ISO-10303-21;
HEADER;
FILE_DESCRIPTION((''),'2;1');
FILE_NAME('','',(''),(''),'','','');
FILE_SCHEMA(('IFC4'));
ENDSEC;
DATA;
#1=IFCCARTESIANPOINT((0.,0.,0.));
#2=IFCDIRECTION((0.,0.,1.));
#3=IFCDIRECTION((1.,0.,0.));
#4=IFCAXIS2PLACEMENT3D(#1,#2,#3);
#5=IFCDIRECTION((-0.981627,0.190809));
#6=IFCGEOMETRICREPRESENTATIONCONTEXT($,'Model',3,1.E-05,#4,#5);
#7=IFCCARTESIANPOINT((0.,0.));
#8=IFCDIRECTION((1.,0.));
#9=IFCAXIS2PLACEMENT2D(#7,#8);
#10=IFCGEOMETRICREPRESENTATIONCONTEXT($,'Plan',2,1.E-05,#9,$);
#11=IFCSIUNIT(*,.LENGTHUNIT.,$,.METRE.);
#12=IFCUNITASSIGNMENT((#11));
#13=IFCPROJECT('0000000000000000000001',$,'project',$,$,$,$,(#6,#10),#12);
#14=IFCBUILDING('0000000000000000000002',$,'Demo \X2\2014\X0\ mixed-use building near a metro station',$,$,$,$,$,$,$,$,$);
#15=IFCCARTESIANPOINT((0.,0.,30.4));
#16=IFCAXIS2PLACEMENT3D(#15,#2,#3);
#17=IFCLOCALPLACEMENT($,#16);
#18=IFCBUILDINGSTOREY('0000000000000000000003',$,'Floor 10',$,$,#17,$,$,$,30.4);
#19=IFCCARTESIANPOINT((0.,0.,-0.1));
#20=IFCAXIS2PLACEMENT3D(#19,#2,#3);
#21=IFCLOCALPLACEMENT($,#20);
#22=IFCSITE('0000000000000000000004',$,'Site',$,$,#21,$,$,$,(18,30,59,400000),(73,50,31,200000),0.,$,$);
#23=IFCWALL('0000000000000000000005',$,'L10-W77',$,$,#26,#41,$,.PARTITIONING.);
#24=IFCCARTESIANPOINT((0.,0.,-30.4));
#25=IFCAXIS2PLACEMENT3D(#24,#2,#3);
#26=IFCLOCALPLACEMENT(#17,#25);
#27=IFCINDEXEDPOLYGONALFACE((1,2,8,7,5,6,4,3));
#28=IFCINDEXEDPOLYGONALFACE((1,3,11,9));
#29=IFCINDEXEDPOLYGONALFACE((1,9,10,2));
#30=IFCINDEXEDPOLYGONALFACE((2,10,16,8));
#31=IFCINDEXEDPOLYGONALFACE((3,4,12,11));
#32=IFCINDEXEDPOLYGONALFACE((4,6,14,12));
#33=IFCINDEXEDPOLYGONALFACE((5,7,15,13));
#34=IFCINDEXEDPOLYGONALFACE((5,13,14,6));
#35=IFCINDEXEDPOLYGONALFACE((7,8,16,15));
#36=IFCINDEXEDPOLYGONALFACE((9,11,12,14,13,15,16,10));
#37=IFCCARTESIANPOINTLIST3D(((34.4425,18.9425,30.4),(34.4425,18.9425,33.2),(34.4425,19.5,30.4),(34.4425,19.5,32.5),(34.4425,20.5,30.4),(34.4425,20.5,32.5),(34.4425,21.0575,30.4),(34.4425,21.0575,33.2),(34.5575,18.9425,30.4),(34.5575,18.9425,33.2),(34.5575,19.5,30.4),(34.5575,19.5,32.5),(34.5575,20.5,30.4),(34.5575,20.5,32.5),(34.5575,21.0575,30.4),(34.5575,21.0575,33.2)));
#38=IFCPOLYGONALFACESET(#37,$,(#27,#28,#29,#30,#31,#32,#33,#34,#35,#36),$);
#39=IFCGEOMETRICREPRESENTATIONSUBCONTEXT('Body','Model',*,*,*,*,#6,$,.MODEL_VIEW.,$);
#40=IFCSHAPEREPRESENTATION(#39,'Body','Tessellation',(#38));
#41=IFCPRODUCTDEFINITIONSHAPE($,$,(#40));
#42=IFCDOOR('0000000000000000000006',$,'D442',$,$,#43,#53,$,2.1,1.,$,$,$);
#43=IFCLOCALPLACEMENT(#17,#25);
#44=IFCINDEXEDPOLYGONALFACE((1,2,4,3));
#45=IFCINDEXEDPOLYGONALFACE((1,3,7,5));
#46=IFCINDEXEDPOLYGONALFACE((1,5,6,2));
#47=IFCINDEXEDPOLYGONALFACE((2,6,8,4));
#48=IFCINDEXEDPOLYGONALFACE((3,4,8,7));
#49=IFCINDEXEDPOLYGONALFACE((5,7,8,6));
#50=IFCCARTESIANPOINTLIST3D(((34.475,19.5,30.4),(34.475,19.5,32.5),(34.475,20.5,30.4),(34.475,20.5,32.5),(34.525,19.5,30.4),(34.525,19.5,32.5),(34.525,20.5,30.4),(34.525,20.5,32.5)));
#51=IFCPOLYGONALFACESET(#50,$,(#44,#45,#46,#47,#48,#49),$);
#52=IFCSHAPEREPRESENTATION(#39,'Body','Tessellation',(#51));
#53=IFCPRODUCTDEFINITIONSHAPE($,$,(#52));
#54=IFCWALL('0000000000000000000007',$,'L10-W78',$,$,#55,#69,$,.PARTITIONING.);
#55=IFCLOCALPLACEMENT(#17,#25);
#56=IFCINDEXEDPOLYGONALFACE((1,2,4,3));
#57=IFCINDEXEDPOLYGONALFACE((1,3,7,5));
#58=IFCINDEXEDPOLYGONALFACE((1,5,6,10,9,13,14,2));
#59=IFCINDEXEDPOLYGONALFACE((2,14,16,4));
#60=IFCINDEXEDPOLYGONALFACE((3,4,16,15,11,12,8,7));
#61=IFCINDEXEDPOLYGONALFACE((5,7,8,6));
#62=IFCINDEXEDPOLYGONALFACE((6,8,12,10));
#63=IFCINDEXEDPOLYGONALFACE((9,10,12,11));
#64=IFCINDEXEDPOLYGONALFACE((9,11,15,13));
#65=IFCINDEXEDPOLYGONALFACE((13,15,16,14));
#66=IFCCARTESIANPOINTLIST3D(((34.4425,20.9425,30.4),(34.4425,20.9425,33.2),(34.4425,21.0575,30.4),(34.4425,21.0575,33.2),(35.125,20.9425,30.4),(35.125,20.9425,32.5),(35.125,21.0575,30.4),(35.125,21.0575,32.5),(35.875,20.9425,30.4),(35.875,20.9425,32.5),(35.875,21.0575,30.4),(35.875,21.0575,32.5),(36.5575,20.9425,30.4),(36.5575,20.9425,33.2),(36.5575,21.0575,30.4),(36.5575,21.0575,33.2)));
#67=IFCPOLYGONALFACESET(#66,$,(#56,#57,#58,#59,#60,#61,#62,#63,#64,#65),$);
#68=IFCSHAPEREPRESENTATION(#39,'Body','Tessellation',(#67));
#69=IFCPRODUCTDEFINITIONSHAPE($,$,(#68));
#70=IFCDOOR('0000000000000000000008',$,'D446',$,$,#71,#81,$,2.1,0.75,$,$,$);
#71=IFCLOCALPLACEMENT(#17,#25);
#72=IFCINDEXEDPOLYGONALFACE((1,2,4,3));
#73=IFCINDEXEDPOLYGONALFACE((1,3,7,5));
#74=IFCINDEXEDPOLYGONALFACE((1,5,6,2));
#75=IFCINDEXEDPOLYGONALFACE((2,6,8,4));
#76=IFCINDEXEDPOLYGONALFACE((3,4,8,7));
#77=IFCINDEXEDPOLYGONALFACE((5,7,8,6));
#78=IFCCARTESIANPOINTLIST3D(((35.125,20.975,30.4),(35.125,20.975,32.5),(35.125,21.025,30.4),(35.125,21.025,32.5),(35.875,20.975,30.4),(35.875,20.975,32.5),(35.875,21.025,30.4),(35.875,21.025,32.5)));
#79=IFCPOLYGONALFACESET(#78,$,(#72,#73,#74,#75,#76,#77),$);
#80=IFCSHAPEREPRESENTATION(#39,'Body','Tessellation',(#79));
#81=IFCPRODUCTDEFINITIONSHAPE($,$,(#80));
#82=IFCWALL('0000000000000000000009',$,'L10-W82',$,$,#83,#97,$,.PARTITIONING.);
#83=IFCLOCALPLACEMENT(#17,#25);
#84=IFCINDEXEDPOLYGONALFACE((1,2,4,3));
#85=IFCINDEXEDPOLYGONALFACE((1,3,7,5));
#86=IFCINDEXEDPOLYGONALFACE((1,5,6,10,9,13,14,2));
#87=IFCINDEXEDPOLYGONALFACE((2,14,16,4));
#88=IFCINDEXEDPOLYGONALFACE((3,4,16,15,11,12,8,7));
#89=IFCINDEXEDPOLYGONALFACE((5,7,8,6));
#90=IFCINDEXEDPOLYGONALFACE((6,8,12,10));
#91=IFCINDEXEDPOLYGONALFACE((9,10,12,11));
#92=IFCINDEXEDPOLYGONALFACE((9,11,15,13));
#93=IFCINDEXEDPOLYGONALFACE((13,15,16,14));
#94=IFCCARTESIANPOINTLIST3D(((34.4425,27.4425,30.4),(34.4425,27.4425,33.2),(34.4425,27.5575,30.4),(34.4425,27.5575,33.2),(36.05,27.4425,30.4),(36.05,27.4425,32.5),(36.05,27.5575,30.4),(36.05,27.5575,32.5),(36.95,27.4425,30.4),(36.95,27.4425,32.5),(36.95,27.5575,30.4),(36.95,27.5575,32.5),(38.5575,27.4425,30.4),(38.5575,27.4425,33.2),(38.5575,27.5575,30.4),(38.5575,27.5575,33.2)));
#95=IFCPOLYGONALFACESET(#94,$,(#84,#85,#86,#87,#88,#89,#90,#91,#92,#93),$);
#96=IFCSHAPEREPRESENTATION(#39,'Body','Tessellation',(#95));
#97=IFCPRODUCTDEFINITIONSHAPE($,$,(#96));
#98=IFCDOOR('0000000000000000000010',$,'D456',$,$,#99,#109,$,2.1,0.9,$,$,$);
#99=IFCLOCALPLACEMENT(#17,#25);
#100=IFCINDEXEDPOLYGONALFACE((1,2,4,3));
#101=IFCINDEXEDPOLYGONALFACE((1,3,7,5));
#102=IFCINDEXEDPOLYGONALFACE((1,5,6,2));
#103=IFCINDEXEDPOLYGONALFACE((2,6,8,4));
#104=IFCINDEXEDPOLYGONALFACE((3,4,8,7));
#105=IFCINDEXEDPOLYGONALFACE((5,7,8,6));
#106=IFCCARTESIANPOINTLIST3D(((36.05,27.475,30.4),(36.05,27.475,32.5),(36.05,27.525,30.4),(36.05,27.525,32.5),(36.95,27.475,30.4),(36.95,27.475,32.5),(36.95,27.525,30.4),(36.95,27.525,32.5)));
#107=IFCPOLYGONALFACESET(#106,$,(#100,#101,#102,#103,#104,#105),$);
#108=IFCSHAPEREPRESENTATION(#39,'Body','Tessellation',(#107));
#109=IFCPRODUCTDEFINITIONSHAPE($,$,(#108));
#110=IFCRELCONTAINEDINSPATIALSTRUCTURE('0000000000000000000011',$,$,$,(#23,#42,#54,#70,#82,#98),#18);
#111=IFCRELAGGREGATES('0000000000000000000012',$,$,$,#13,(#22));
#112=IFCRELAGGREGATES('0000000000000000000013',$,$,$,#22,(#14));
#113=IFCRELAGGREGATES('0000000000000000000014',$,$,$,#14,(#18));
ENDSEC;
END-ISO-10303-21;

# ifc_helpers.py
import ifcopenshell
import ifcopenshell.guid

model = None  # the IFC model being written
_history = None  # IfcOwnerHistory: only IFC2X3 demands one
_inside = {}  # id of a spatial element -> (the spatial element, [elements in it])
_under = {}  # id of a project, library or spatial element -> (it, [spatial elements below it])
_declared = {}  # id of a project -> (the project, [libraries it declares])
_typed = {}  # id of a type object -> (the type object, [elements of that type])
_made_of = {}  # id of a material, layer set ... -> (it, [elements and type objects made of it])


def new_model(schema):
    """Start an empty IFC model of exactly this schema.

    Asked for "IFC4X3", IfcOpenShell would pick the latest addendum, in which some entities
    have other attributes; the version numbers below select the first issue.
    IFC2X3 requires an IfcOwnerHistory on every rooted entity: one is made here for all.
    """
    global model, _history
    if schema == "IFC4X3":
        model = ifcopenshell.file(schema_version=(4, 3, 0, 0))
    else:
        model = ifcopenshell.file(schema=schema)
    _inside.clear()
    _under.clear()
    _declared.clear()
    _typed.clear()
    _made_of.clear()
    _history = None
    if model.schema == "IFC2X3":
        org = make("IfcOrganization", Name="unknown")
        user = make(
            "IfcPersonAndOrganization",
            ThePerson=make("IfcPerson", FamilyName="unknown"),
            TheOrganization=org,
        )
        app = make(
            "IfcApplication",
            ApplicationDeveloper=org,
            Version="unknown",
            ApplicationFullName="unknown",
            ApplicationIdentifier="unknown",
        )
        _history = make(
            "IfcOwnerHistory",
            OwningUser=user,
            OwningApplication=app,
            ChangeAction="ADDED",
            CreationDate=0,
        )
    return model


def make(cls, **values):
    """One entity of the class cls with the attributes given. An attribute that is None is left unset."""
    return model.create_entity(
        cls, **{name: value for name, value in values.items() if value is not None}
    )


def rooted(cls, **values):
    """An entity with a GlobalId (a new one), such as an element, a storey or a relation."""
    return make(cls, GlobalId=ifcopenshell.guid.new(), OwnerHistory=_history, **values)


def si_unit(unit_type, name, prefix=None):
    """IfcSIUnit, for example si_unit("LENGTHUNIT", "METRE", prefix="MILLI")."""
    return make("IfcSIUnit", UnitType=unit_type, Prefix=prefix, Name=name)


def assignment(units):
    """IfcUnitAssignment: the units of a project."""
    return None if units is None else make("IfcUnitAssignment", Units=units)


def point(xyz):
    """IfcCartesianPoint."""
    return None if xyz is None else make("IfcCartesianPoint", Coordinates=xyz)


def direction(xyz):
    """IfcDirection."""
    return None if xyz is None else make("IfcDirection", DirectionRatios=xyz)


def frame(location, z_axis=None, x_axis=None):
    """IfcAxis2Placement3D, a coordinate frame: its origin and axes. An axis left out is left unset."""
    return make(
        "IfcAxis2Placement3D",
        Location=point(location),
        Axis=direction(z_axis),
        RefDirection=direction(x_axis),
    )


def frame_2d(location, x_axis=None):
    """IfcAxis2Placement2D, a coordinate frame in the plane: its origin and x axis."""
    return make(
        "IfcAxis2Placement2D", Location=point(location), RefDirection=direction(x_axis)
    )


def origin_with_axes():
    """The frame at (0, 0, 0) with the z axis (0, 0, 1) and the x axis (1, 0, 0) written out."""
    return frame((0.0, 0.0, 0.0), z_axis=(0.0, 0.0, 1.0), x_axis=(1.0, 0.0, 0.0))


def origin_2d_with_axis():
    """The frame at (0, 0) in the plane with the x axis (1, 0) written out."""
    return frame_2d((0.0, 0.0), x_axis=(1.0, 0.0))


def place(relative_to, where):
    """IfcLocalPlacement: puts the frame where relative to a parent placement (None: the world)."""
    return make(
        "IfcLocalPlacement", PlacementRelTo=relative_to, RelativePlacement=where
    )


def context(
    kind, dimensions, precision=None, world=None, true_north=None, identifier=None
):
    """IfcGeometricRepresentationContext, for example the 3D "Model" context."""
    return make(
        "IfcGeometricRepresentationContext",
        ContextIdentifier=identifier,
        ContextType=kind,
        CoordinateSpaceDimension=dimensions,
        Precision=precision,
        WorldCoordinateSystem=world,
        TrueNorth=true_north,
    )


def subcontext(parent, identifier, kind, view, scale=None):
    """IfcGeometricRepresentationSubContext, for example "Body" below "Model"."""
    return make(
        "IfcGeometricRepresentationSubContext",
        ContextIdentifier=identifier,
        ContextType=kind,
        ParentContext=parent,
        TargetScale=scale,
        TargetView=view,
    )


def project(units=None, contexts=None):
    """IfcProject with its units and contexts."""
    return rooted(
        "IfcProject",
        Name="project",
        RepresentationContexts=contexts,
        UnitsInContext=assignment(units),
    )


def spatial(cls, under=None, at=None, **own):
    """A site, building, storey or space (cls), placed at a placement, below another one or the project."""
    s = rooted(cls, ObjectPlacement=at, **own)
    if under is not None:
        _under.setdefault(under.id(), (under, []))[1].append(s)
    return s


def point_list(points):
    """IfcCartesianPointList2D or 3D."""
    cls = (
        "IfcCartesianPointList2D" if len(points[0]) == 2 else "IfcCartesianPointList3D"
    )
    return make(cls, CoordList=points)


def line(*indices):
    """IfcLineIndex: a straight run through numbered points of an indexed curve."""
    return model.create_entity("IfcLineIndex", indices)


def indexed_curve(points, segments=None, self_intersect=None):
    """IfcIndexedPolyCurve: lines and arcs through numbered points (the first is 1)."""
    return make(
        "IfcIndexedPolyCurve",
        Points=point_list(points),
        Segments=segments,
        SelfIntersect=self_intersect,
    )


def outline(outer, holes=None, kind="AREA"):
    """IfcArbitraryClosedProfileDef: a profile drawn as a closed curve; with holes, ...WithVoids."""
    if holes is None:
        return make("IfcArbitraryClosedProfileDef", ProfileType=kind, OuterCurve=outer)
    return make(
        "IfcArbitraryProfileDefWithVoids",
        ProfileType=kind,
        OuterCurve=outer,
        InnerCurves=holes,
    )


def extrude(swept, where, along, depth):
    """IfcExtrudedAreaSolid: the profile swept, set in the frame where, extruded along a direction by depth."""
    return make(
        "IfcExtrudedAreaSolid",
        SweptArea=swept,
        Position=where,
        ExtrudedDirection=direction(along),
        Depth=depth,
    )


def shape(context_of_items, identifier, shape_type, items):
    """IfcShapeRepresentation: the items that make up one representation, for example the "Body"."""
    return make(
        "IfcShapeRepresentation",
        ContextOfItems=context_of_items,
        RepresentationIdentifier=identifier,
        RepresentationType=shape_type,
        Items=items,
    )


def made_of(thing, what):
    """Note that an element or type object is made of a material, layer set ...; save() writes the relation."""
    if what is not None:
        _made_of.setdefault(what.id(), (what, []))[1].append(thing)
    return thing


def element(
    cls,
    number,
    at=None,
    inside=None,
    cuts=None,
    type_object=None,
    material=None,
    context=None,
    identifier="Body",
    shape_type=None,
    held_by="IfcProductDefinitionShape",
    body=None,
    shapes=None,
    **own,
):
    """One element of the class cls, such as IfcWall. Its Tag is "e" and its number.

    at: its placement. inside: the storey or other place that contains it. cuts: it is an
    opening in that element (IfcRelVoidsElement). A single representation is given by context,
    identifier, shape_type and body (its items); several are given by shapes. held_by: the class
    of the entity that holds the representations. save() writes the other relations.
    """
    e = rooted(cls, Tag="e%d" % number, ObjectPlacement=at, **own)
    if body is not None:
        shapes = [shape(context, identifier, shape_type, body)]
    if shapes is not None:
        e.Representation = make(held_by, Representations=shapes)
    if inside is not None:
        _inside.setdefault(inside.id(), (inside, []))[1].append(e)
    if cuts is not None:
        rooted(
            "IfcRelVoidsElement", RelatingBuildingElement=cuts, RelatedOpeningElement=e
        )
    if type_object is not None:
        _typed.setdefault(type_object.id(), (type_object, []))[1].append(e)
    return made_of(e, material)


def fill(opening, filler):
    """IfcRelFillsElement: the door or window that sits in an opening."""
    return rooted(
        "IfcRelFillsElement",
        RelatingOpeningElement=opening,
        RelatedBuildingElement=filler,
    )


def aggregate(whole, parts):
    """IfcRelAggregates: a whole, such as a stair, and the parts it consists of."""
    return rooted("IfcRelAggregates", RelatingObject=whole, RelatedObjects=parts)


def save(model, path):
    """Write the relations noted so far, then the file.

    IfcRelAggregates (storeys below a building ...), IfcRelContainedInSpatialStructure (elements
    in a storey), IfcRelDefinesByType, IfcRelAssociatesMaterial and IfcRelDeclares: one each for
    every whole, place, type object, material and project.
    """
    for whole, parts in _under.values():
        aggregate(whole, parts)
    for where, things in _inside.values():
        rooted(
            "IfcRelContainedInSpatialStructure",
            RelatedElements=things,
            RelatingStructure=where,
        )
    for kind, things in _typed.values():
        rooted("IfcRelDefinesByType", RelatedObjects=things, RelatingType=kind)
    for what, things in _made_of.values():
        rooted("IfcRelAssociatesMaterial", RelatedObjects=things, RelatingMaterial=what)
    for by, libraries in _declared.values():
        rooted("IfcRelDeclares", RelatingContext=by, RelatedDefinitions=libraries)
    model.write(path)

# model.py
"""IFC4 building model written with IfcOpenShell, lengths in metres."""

from ifc_helpers import new_model, si_unit, direction, frame, origin_with_axes, origin_2d_with_axis, place, context, subcontext, project, spatial, line, indexed_curve, outline, extrude, element, fill, save


model = new_model("IFC4")

# Units and contexts
model_context = context("Model", 3, precision=1e-05, world=origin_with_axes(), true_north=direction((-0.981627, 0.190809)))
plan_context = context("Plan", 2, precision=1e-05, world=origin_2d_with_axis())
body_context = subcontext(model_context, "Body", "Model", "MODEL_VIEW")
ifc_project = project(units=[si_unit("LENGTHUNIT", "METRE")], contexts=[model_context, plan_context])

# Site, building, storey
site_placement = place(None, frame((0.0, 0.0, -0.1), z_axis=(0.0, 0.0, 1.0), x_axis=(1.0, 0.0, 0.0)))
site = spatial("IfcSite", under=ifc_project, at=site_placement, Name="Site", RefLatitude=(18, 30, 59, 400000), RefLongitude=(73, 50, 31, 200000), RefElevation=0.0)
building = spatial("IfcBuilding", under=site, Name="Demo — mixed-use building near a metro station")
storey_placement = place(None, frame((0.0, 0.0, 30.4), z_axis=(0.0, 0.0, 1.0), x_axis=(1.0, 0.0, 0.0)))
storey = spatial("IfcBuildingStorey", under=building, at=storey_placement, Name="Floor 10", Elevation=30.4)

# Walls, openings, doors
wall_1_placement = place(storey_placement, frame((0.0, 0.0, -30.4), z_axis=(0.0, 0.0, 1.0), x_axis=(1.0, 0.0, 0.0)))
wall_1 = element("IfcWall", 1, at=wall_1_placement, inside=storey, Name="L10-W77", PredefinedType="PARTITIONING", context=body_context, shape_type="SweptSolid", body=[
    extrude(outline(indexed_curve([(34.4425, 18.9425), (34.4425, 21.0575), (34.5575, 21.0575), (34.5575, 18.9425)], segments=[line(1, 2, 3, 4, 1)])), frame((0.0, 0.0, 30.4), z_axis=(0.0, 0.0, 1.0), x_axis=(1.0, 0.0, 0.0)), (0.0, 0.0, 1.0), 2.8),
])
opening_1_placement = place(wall_1_placement, origin_with_axes())
opening_1 = element("IfcOpeningElement", 2, at=opening_1_placement, cuts=wall_1, context=body_context, shape_type="SweptSolid", body=[
    extrude(outline(indexed_curve([(34.3925, 19.5), (34.3925, 20.5), (34.6075, 20.5), (34.6075, 19.5)], segments=[line(1, 2, 3, 4, 1)])), frame((0.0, 0.0, 30.4), z_axis=(0.0, 0.0, 1.0), x_axis=(1.0, 0.0, 0.0)), (0.0, 0.0, 1.0), 2.1),
])
door_1_placement = place(storey_placement, frame((0.0, 0.0, -30.4), z_axis=(0.0, 0.0, 1.0), x_axis=(1.0, 0.0, 0.0)))
door_1 = element("IfcDoor", 3, at=door_1_placement, inside=storey, Name="D442", OverallHeight=2.1, OverallWidth=1.0, context=body_context, shape_type="SweptSolid", body=[
    extrude(outline(indexed_curve([(34.475, 19.5), (34.475, 20.5), (34.525, 20.5), (34.525, 19.5)], segments=[line(1, 2, 3, 4, 1)])), frame((0.0, 0.0, 30.4), z_axis=(0.0, 0.0, 1.0), x_axis=(1.0, 0.0, 0.0)), (0.0, 0.0, 1.0), 2.1),
])
fill(opening_1, door_1)
wall_2_placement = place(storey_placement, frame((0.0, 0.0, -30.4), z_axis=(0.0, 0.0, 1.0), x_axis=(1.0, 0.0, 0.0)))
wall_2 = element("IfcWall", 4, at=wall_2_placement, inside=storey, Name="L10-W78", PredefinedType="PARTITIONING", context=body_context, shape_type="SweptSolid", body=[
    extrude(outline(indexed_curve([(36.5575, 20.9425), (34.4425, 20.9425), (34.4425, 21.0575), (36.5575, 21.0575)], segments=[line(1, 2, 3, 4, 1)])), frame((0.0, 0.0, 30.4), z_axis=(0.0, 0.0, 1.0), x_axis=(1.0, 0.0, 0.0)), (0.0, 0.0, 1.0), 2.8),
])
opening_2_placement = place(wall_2_placement, origin_with_axes())
opening_2 = element("IfcOpeningElement", 5, at=opening_2_placement, cuts=wall_2, context=body_context, shape_type="SweptSolid", body=[
    extrude(outline(indexed_curve([(35.875, 20.8925), (35.125, 20.8925), (35.125, 21.1075), (35.875, 21.1075)], segments=[line(1, 2, 3, 4, 1)])), frame((0.0, 0.0, 30.4), z_axis=(0.0, 0.0, 1.0), x_axis=(1.0, 0.0, 0.0)), (0.0, 0.0, 1.0), 2.1),
])
door_2_placement = place(storey_placement, frame((0.0, 0.0, -30.4), z_axis=(0.0, 0.0, 1.0), x_axis=(1.0, 0.0, 0.0)))
door_2 = element("IfcDoor", 6, at=door_2_placement, inside=storey, Name="D446", OverallHeight=2.1, OverallWidth=0.75, context=body_context, shape_type="SweptSolid", body=[
    extrude(outline(indexed_curve([(35.875, 20.975), (35.125, 20.975), (35.125, 21.025), (35.875, 21.025)], segments=[line(1, 2, 3, 4, 1)])), frame((0.0, 0.0, 30.4), z_axis=(0.0, 0.0, 1.0), x_axis=(1.0, 0.0, 0.0)), (0.0, 0.0, 1.0), 2.1),
])
fill(opening_2, door_2)

# Wall, opening, door
wall_3_placement = place(storey_placement, frame((0.0, 0.0, -30.4), z_axis=(0.0, 0.0, 1.0), x_axis=(1.0, 0.0, 0.0)))
wall_3 = element("IfcWall", 7, at=wall_3_placement, inside=storey, Name="L10-W82", PredefinedType="PARTITIONING", context=body_context, shape_type="SweptSolid", body=[
    extrude(outline(indexed_curve([(38.5575, 27.4425), (34.4425, 27.4425), (34.4425, 27.5575), (38.5575, 27.5575)], segments=[line(1, 2, 3, 4, 1)])), frame((0.0, 0.0, 30.4), z_axis=(0.0, 0.0, 1.0), x_axis=(1.0, 0.0, 0.0)), (0.0, 0.0, 1.0), 2.8),
])
opening_3_placement = place(wall_3_placement, origin_with_axes())
opening_3 = element("IfcOpeningElement", 8, at=opening_3_placement, cuts=wall_3, context=body_context, shape_type="SweptSolid", body=[
    extrude(outline(indexed_curve([(36.95, 27.3925), (36.05, 27.3925), (36.05, 27.6075), (36.95, 27.6075)], segments=[line(1, 2, 3, 4, 1)])), frame((0.0, 0.0, 30.4), z_axis=(0.0, 0.0, 1.0), x_axis=(1.0, 0.0, 0.0)), (0.0, 0.0, 1.0), 2.1),
])
door_3_placement = place(storey_placement, frame((0.0, 0.0, -30.4), z_axis=(0.0, 0.0, 1.0), x_axis=(1.0, 0.0, 0.0)))
door_3 = element("IfcDoor", 9, at=door_3_placement, inside=storey, Name="D456", OverallHeight=2.1, OverallWidth=0.9, context=body_context, shape_type="SweptSolid", body=[
    extrude(outline(indexed_curve([(36.95, 27.475), (36.05, 27.475), (36.05, 27.525), (36.95, 27.525)], segments=[line(1, 2, 3, 4, 1)])), frame((0.0, 0.0, 30.4), z_axis=(0.0, 0.0, 1.0), x_axis=(1.0, 0.0, 0.0)), (0.0, 0.0, 1.0), 2.1),
])
fill(opening_3, door_3)

save(model, "model.ifc")
